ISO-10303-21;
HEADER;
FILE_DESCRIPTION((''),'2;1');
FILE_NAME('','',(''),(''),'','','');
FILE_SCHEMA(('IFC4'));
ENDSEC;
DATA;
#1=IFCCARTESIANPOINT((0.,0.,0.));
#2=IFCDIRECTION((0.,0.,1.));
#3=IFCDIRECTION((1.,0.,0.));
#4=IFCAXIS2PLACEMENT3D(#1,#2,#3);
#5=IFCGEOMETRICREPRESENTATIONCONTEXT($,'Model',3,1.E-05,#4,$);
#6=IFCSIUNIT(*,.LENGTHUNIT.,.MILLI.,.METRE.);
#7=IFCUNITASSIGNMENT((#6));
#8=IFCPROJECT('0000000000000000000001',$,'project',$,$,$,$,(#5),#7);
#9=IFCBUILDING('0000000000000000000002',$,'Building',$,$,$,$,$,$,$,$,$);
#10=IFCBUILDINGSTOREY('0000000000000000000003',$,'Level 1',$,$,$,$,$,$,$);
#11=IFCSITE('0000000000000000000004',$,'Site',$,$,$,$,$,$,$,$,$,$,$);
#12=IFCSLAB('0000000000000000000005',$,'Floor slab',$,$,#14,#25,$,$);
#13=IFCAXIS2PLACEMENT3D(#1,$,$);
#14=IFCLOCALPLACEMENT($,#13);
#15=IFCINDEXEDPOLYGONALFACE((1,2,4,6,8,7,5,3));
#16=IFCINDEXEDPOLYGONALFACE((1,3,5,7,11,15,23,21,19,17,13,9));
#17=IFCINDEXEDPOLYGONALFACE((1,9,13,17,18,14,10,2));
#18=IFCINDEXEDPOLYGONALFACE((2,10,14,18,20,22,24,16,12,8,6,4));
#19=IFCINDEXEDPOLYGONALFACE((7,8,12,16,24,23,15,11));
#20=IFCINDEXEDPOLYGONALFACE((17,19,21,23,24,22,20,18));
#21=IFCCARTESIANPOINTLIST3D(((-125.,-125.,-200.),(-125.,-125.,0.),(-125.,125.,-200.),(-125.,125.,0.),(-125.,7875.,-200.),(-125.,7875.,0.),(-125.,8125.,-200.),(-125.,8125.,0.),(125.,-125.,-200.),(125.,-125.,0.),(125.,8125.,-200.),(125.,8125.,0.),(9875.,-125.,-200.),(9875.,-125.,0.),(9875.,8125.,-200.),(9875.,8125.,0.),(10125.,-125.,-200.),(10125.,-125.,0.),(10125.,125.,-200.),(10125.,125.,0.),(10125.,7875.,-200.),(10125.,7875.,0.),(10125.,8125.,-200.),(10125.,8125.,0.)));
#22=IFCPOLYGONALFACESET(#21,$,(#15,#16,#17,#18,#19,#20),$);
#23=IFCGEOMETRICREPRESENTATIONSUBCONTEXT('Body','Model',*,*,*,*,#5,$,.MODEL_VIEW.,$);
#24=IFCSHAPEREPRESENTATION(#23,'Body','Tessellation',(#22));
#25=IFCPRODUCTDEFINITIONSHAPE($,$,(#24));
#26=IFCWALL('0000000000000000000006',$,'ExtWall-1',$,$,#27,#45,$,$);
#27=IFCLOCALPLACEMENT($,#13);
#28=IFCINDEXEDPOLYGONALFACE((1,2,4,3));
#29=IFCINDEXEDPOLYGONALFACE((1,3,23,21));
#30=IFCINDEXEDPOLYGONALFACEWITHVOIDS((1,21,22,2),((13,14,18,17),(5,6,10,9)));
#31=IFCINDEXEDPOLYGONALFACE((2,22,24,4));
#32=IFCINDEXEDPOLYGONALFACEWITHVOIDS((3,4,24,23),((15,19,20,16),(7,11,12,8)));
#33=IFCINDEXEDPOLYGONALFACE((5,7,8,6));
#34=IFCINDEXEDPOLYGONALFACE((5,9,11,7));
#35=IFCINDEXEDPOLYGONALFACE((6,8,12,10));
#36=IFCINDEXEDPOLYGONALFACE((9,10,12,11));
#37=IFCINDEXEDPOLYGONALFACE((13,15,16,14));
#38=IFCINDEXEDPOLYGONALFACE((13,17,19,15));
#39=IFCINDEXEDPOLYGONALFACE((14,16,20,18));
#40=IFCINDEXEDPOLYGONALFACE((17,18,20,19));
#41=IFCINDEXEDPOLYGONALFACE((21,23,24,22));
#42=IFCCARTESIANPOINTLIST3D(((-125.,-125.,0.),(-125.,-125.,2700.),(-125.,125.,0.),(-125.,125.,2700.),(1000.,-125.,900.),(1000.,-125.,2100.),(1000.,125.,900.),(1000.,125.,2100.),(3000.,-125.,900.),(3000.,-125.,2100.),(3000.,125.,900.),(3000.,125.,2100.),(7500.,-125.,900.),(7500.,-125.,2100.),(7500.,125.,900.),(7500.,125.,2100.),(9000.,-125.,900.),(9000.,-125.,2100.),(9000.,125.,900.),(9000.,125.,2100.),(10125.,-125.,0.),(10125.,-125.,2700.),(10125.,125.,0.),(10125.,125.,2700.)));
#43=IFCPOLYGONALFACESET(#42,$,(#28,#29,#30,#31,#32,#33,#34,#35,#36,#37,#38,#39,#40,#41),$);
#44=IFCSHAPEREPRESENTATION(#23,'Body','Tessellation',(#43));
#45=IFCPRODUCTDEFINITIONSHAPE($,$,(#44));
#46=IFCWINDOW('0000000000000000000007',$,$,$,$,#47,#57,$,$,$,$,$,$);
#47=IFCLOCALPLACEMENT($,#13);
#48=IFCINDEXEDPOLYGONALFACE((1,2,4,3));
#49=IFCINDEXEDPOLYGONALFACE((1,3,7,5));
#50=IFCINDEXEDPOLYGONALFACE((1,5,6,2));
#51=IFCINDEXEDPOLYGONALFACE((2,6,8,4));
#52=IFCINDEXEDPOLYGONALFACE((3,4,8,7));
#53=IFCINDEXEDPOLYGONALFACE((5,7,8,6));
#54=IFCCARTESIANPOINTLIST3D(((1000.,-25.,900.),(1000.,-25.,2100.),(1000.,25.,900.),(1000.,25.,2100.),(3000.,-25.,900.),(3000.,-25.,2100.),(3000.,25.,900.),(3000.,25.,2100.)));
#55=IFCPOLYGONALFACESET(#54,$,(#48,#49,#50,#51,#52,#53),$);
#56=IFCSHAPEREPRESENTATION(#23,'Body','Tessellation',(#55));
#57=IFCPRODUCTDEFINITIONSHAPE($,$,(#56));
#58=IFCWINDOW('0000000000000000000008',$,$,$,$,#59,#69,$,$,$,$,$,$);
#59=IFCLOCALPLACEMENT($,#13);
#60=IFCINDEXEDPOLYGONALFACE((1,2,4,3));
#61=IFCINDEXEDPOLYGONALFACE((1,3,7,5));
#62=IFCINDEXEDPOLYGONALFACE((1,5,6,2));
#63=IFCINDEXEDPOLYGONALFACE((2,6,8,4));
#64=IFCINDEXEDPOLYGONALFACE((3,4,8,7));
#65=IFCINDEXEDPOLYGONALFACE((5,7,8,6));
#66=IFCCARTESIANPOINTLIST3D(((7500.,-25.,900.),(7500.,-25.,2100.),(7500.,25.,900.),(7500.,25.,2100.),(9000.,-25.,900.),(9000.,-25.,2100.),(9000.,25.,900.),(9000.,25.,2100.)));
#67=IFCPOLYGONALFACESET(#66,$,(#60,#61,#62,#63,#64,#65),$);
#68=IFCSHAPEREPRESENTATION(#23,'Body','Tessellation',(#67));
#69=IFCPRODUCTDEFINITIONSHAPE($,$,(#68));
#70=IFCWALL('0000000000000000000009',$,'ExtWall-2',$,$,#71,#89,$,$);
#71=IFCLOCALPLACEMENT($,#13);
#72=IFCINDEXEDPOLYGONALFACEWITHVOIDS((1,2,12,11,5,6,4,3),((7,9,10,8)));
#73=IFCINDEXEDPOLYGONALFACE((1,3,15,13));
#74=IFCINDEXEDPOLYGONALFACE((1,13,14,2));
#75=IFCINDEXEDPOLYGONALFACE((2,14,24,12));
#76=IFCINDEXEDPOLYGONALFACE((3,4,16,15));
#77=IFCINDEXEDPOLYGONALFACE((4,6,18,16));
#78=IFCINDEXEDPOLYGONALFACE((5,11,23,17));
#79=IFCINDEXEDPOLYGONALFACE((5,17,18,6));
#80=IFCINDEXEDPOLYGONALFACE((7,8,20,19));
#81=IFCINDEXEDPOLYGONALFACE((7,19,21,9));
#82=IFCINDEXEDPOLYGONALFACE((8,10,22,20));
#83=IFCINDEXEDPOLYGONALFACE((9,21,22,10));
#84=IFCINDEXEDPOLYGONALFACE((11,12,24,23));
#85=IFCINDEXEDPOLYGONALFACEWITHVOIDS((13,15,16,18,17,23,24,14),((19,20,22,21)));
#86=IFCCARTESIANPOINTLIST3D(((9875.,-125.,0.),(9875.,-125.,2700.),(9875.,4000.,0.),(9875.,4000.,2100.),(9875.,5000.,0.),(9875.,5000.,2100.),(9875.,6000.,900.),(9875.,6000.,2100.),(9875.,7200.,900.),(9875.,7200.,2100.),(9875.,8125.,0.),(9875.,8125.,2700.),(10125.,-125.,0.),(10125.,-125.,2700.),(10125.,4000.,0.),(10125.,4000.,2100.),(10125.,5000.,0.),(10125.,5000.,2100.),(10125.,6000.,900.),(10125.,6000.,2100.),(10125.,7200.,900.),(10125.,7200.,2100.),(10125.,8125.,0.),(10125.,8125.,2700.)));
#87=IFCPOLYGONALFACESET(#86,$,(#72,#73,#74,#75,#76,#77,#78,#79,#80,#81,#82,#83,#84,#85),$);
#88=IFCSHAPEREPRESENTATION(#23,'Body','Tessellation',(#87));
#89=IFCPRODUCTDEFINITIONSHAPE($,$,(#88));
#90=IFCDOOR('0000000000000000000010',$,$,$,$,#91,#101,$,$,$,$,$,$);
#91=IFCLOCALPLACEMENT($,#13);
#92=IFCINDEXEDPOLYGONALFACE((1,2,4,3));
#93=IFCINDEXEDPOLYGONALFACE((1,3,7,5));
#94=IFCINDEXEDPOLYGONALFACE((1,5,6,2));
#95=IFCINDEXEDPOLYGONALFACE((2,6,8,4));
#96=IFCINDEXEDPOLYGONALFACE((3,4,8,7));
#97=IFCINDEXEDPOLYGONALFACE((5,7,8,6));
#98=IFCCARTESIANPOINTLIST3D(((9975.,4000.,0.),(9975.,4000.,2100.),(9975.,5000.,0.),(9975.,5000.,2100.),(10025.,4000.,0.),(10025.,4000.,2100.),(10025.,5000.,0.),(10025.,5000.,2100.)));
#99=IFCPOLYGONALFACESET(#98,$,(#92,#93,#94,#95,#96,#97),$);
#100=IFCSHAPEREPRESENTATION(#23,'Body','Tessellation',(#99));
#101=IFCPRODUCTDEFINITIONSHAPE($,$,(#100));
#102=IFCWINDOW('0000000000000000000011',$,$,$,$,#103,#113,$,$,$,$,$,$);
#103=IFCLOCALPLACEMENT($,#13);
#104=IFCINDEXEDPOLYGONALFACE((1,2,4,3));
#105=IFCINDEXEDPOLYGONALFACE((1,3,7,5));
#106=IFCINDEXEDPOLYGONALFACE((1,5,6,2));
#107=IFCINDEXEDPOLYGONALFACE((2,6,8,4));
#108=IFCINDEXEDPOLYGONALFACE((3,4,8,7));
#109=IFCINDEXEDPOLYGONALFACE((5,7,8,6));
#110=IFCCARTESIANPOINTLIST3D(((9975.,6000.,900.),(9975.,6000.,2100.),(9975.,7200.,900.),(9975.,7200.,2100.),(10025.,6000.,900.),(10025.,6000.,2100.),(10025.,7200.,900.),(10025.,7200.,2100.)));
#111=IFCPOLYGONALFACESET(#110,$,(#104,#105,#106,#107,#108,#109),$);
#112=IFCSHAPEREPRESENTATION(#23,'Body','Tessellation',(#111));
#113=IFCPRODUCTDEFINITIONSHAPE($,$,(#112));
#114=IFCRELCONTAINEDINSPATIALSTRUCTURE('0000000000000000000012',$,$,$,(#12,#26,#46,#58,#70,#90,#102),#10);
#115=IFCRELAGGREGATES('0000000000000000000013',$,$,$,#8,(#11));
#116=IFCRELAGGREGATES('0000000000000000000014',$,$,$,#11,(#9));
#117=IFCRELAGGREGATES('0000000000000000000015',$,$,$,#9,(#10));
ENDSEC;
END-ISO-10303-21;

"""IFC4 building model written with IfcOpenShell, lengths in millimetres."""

from ifc_helpers import new_model, si_unit, frame, origin_with_axes, place, context, subcontext, project, spatial, indexed_curve, outline, extrude, element, fill, save


model = new_model("IFC4")

# Units and contexts
model_context = context("Model", 3, precision=1e-05, world=origin_with_axes())
body_context = subcontext(model_context, "Body", "Model", "MODEL_VIEW")
ifc_project = project(units=[si_unit("LENGTHUNIT", "METRE", prefix="MILLI")], contexts=[model_context])

# Site, building, storey
site = spatial("IfcSite", under=ifc_project, Name="Site")
building = spatial("IfcBuilding", under=site, Name="Building")
storey = spatial("IfcBuildingStorey", under=building, Name="Level 1")

# Slab
slab_placement = place(None, frame((0.0, 0.0, -200.0), z_axis=(0.0, 0.0, 1.0), x_axis=(1.0, 0.0, 0.0)))
element("IfcSlab", 1, at=slab_placement, inside=storey, Name="Floor slab", context=body_context, shape_type="SweptSolid", body=[
    extrude(outline(indexed_curve([(-125.0, -125.0), (-125.0, 125.0), (-125.0, 7875.0), (-125.0, 8125.0), (125.0, 8125.0), (9875.0, 8125.0), (10125.0, 8125.0), (10125.0, 7875.0), (10125.0, 125.0), (10125.0, -125.0), (9875.0, -125.0), (125.0, -125.0)])), None, (0.0, 0.0, 1.0), 200.0),
])

# Wall, openings, windows
wall_1_placement = place(None, frame((-125.0, 0.0, 0.0), z_axis=(0.0, 0.0, 1.0), x_axis=(1.0, 0.0, 0.0)))
wall_1 = element("IfcWall", 2, at=wall_1_placement, inside=storey, Name="ExtWall-1", context=body_context, shape_type="SweptSolid", body=[
    extrude(outline(indexed_curve([(0.0, 0.0), (0.0, 250.0), (10250.0, 250.0), (10250.0, 0.0), (0.0, 0.0)], self_intersect=False)), frame((0.0, -125.0, 0.0), z_axis=(0.0, 0.0, 1.0), x_axis=(1.0, 0.0, 0.0)), (0.0, 0.0, 1.0), 2700.0),
])
opening_1_placement = place(wall_1_placement, frame((1125.0, 0.0, 900.0), z_axis=(0.0, 0.0, 1.0), x_axis=(1.0, 0.0, 0.0)))
opening_1 = element("IfcOpeningElement", 3, at=opening_1_placement, cuts=wall_1, context=body_context, shape_type="SweptSolid", body=[
    extrude(outline(indexed_curve([(0.0, 0.0), (0.0, 350.0), (2000.0, 350.0), (2000.0, 0.0), (0.0, 0.0)], self_intersect=False)), frame((0.0, -175.0, 0.0), z_axis=(0.0, 0.0, 1.0), x_axis=(1.0, 0.0, 0.0)), (0.0, 0.0, 1.0), 1200.0),
])
opening_2_placement = place(wall_1_placement, frame((7625.0, 0.0, 900.0), z_axis=(0.0, 0.0, 1.0), x_axis=(1.0, 0.0, 0.0)))
opening_2 = element("IfcOpeningElement", 4, at=opening_2_placement, cuts=wall_1, context=body_context, shape_type="SweptSolid", body=[
    extrude(outline(indexed_curve([(0.0, 0.0), (0.0, 350.0), (1500.0, 350.0), (1500.0, 0.0), (0.0, 0.0)], self_intersect=False)), frame((0.0, -175.0, 0.0), z_axis=(0.0, 0.0, 1.0), x_axis=(1.0, 0.0, 0.0)), (0.0, 0.0, 1.0), 1200.0),
])
window_1_placement = place(opening_1_placement, origin_with_axes())
window_1 = element("IfcWindow", 5, at=window_1_placement, inside=storey, context=body_context, shape_type="SweptSolid", body=[
    extrude(outline(indexed_curve([(0.0, 0.0), (0.0, 50.0), (2000.0, 50.0), (2000.0, 0.0), (0.0, 0.0)], self_intersect=False)), frame((0.0, -25.0, 0.0), z_axis=(0.0, 0.0, 1.0), x_axis=(1.0, 0.0, 0.0)), (0.0, 0.0, 1.0), 1200.0),
])
fill(opening_1, window_1)
window_2_placement = place(opening_2_placement, origin_with_axes())
window_2 = element("IfcWindow", 6, at=window_2_placement, inside=storey, context=body_context, shape_type="SweptSolid", body=[
    extrude(outline(indexed_curve([(0.0, 0.0), (0.0, 50.0), (1500.0, 50.0), (1500.0, 0.0), (0.0, 0.0)], self_intersect=False)), frame((0.0, -25.0, 0.0), z_axis=(0.0, 0.0, 1.0), x_axis=(1.0, 0.0, 0.0)), (0.0, 0.0, 1.0), 1200.0),
])
fill(opening_2, window_2)

# Wall, openings, door, window
wall_2_placement = place(None, frame((10000.0, -125.0, 0.0), z_axis=(0.0, 0.0, 1.0), x_axis=(0.0, 1.0, 0.0)))
wall_2 = element("IfcWall", 7, at=wall_2_placement, inside=storey, Name="ExtWall-2", context=body_context, shape_type="SweptSolid", body=[
    extrude(outline(indexed_curve([(0.0, 0.0), (0.0, 250.0), (8250.0, 250.0), (8250.0, 0.0), (0.0, 0.0)], self_intersect=False)), frame((0.0, -125.0, 0.0), z_axis=(0.0, 0.0, 1.0), x_axis=(1.0, 0.0, 0.0)), (0.0, 0.0, 1.0), 2700.0),
])
opening_3_placement = place(wall_2_placement, frame((4125.0, 0.0, 0.0), z_axis=(0.0, 0.0, 1.0), x_axis=(1.0, 0.0, 0.0)))
opening_3 = element("IfcOpeningElement", 8, at=opening_3_placement, cuts=wall_2, context=body_context, shape_type="SweptSolid", body=[
    extrude(outline(indexed_curve([(0.0, 0.0), (0.0, 350.0), (1000.0, 350.0), (1000.0, 0.0), (0.0, 0.0)], self_intersect=False)), frame((0.0, -175.0, 0.0), z_axis=(0.0, 0.0, 1.0), x_axis=(1.0, 0.0, 0.0)), (0.0, 0.0, 1.0), 2100.0),
])
opening_4_placement = place(wall_2_placement, frame((6125.0, 0.0, 900.0), z_axis=(0.0, 0.0, 1.0), x_axis=(1.0, 0.0, 0.0)))
opening_4 = element("IfcOpeningElement", 9, at=opening_4_placement, cuts=wall_2, context=body_context, shape_type="SweptSolid", body=[
    extrude(outline(indexed_curve([(0.0, 0.0), (0.0, 350.0), (1200.0, 350.0), (1200.0, 0.0), (0.0, 0.0)], self_intersect=False)), frame((0.0, -175.0, 0.0), z_axis=(0.0, 0.0, 1.0), x_axis=(1.0, 0.0, 0.0)), (0.0, 0.0, 1.0), 1200.0),
])
door_1_placement = place(opening_3_placement, origin_with_axes())
door_1 = element("IfcDoor", 10, at=door_1_placement, inside=storey, context=body_context, shape_type="SweptSolid", body=[
    extrude(outline(indexed_curve([(0.0, 0.0), (0.0, 50.0), (1000.0, 50.0), (1000.0, 0.0), (0.0, 0.0)], self_intersect=False)), frame((0.0, -25.0, 0.0), z_axis=(0.0, 0.0, 1.0), x_axis=(1.0, 0.0, 0.0)), (0.0, 0.0, 1.0), 2100.0),
])
fill(opening_3, door_1)
window_3_placement = place(opening_4_placement, origin_with_axes())
window_3 = element("IfcWindow", 11, at=window_3_placement, inside=storey, context=body_context, shape_type="SweptSolid", body=[
    extrude(outline(indexed_curve([(0.0, 0.0), (0.0, 50.0), (1200.0, 50.0), (1200.0, 0.0), (0.0, 0.0)], self_intersect=False)), frame((0.0, -25.0, 0.0), z_axis=(0.0, 0.0, 1.0), x_axis=(1.0, 0.0, 0.0)), (0.0, 0.0, 1.0), 1200.0),
])
fill(opening_4, window_3)

save(model, "model.ifc")
